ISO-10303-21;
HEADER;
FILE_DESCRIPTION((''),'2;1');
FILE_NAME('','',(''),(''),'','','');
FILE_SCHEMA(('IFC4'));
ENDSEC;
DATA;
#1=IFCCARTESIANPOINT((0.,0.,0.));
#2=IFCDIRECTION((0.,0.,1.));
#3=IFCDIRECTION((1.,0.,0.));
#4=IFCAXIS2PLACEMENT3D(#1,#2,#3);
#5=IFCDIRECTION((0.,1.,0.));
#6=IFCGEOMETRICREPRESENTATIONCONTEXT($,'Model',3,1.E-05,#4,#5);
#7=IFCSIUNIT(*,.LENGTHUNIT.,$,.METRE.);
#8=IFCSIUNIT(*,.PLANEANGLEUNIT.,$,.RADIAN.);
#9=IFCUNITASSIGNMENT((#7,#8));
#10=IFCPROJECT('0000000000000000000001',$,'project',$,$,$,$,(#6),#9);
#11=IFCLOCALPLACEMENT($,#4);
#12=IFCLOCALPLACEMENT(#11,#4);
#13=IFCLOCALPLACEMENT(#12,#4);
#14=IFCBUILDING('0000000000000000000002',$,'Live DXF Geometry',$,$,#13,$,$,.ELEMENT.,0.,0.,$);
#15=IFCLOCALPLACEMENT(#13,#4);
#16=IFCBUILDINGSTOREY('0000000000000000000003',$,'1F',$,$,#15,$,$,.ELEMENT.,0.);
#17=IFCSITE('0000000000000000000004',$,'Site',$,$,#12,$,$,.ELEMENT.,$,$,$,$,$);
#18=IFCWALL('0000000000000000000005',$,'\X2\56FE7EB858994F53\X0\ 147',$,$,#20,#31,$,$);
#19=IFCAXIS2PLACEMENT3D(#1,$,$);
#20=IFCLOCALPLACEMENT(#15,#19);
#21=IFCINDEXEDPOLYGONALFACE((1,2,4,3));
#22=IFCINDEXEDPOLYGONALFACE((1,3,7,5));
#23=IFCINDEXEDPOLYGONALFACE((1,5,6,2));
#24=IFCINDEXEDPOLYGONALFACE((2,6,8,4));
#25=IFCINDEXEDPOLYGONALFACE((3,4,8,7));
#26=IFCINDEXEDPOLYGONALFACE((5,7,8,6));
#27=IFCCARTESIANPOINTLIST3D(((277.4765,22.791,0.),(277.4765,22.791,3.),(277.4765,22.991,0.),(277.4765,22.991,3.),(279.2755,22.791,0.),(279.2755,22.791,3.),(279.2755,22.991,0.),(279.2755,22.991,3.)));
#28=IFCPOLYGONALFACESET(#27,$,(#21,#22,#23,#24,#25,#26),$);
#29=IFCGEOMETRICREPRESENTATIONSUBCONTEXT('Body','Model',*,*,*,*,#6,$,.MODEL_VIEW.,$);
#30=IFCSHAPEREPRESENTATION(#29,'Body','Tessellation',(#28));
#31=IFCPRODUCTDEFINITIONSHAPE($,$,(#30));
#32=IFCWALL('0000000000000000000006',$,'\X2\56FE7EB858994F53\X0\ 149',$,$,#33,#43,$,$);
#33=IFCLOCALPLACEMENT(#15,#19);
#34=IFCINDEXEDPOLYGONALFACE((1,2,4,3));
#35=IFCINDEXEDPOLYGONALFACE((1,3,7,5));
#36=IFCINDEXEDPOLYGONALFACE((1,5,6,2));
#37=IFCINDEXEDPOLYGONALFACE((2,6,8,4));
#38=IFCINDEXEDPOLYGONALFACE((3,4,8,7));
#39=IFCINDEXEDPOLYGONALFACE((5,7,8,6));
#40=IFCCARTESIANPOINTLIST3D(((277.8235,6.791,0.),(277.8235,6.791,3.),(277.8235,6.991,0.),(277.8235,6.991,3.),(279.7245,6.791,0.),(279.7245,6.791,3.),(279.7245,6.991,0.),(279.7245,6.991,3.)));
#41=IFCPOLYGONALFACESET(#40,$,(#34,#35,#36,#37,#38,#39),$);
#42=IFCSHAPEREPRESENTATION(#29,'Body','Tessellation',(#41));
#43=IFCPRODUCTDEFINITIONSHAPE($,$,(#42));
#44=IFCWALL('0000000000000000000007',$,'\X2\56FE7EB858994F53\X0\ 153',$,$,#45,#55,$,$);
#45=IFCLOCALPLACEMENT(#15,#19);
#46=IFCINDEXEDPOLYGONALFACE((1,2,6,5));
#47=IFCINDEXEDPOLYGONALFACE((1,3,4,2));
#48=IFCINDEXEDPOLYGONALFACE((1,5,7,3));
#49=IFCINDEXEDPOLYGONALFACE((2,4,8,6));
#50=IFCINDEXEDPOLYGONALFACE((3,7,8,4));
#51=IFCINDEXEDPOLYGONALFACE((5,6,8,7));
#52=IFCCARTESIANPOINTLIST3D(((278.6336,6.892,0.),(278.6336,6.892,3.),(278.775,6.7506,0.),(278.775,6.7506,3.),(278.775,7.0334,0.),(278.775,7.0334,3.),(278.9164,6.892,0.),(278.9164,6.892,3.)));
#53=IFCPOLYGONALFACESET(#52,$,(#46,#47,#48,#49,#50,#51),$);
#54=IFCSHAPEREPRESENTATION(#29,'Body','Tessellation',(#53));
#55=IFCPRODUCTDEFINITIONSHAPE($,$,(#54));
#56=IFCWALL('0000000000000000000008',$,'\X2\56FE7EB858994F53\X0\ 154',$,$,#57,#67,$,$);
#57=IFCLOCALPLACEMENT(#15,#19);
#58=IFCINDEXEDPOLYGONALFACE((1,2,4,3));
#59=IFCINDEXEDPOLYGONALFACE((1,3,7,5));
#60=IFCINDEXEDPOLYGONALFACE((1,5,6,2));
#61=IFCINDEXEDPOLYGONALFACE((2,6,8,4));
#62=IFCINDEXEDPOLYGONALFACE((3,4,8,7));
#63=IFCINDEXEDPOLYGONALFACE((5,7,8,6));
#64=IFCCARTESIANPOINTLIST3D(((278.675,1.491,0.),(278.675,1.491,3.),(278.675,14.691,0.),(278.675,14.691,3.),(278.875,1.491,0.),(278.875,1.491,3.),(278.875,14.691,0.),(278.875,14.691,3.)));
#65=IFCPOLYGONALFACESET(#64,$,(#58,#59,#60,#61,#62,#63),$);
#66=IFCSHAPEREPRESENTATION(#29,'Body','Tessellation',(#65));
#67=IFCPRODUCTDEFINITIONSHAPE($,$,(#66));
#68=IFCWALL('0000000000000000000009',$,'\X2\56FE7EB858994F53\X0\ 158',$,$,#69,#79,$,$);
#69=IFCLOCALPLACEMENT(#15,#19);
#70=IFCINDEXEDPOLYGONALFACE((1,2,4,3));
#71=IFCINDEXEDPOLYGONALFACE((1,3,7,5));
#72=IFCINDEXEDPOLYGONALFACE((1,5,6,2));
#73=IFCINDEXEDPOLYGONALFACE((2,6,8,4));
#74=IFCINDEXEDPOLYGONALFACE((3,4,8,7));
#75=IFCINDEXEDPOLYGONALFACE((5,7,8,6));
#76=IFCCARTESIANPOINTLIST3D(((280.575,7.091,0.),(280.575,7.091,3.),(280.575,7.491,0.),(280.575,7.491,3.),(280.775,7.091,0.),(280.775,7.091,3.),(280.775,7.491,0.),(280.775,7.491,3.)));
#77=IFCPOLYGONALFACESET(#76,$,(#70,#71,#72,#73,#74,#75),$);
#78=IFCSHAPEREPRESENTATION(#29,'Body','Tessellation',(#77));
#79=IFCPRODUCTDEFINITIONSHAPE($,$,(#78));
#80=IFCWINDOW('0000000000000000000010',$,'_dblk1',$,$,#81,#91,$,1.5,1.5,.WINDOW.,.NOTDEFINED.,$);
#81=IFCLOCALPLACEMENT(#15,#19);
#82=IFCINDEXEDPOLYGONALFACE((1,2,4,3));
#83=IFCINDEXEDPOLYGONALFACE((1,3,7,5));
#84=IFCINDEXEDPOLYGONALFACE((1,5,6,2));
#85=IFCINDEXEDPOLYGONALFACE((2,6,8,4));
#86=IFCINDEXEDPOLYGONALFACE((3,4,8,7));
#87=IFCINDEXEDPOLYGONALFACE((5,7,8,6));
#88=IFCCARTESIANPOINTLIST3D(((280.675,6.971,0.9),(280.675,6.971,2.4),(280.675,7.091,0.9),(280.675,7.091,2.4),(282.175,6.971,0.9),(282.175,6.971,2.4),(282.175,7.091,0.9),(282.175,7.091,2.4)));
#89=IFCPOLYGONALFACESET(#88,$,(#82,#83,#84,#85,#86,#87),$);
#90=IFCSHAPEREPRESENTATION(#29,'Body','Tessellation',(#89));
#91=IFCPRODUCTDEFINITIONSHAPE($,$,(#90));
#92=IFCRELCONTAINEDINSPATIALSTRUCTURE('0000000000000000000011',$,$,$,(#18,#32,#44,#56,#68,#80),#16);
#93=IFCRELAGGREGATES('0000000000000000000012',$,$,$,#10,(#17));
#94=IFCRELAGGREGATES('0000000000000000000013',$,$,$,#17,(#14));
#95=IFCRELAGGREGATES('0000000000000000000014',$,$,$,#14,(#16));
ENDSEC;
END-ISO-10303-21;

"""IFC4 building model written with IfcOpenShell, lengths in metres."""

from ifc_helpers import new_model, si_unit, direction, frame, frame_2d, origin_with_axes, place, context, subcontext, project, spatial, rectangle, extrude, element, save


model = new_model("IFC4")

# Units and contexts
model_context = context("Model", 3, precision=1e-05, world=origin_with_axes(), true_north=direction((0.0, 1.0, 0.0)))
body_context = subcontext(model_context, "Body", "Model", "MODEL_VIEW")
ifc_project = project(units=[si_unit("LENGTHUNIT", "METRE"), si_unit("PLANEANGLEUNIT", "RADIAN")], contexts=[model_context])

# Site, building, storey
placement = place(None, origin_with_axes())
site_placement = place(placement, origin_with_axes())
site = spatial("IfcSite", under=ifc_project, at=site_placement, Name="Site", CompositionType="ELEMENT")
building_placement = place(site_placement, origin_with_axes())
building = spatial("IfcBuilding", under=site, at=building_placement, Name="Live DXF Geometry", CompositionType="ELEMENT", ElevationOfRefHeight=0.0, ElevationOfTerrain=0.0)
storey_placement = place(building_placement, origin_with_axes())
storey = spatial("IfcBuildingStorey", under=building, at=storey_placement, Name="1F", CompositionType="ELEMENT", Elevation=0.0)

# Walls
wall_1_placement = place(storey_placement, frame((278.376, 22.891, 0.0), z_axis=(0.0, 0.0, 1.0), x_axis=(1.0, 0.0, 0.0)))
element("IfcWall", 1, at=wall_1_placement, inside=storey, Name="图纸墙体 147", context=body_context, shape_type="SweptSolid", body=[
    extrude(rectangle(XDim=1.799, YDim=0.2, at=frame_2d((0.0, 0.0), x_axis=(1.0, 0.0, 0.0))), frame((0.0, 0.0, 0.0), z_axis=(0.0, 0.0, 1.0)), (0.0, 0.0, 1.0), 3.0),
])
wall_2_placement = place(storey_placement, frame((278.774, 6.891, 0.0), z_axis=(0.0, 0.0, 1.0), x_axis=(1.0, 0.0, 0.0)))
element("IfcWall", 2, at=wall_2_placement, inside=storey, Name="图纸墙体 149", context=body_context, shape_type="SweptSolid", body=[
    extrude(rectangle(XDim=1.901, YDim=0.2, at=frame_2d((0.0, 0.0), x_axis=(1.0, 0.0, 0.0))), frame((0.0, 0.0, 0.0), z_axis=(0.0, 0.0, 1.0)), (0.0, 0.0, 1.0), 3.0),
])
wall_3_placement = place(storey_placement, frame((278.775, 6.892, 0.0), z_axis=(0.0, 0.0, 1.0), x_axis=(-0.707107, -0.707107, 0.0)))
element("IfcWall", 3, at=wall_3_placement, inside=storey, Name="图纸墙体 153", context=body_context, shape_type="SweptSolid", body=[
    extrude(rectangle(XDim=0.2, YDim=0.2, at=frame_2d((0.0, 0.0), x_axis=(1.0, 0.0, 0.0))), frame((0.0, 0.0, 0.0), z_axis=(0.0, 0.0, 1.0)), (0.0, 0.0, 1.0), 3.0),
])
wall_4_placement = place(storey_placement, frame((278.775, 8.091, 0.0), z_axis=(0.0, 0.0, 1.0), x_axis=(0.0, 1.0, 0.0)))
element("IfcWall", 4, at=wall_4_placement, inside=storey, Name="图纸墙体 154", context=body_context, shape_type="SweptSolid", body=[
    extrude(rectangle(XDim=13.2, YDim=0.2, at=frame_2d((0.0, 0.0), x_axis=(1.0, 0.0, 0.0))), frame((0.0, 0.0, 0.0), z_axis=(0.0, 0.0, 1.0)), (0.0, 0.0, 1.0), 3.0),
])
wall_5_placement = place(storey_placement, frame((280.675, 7.291, 0.0), z_axis=(0.0, 0.0, 1.0), x_axis=(0.0, -1.0, 0.0)))
element("IfcWall", 5, at=wall_5_placement, inside=storey, Name="图纸墙体 158", context=body_context, shape_type="SweptSolid", body=[
    extrude(rectangle(XDim=0.4, YDim=0.2, at=frame_2d((0.0, 0.0), x_axis=(1.0, 0.0, 0.0))), frame((0.0, 0.0, 0.0), z_axis=(0.0, 0.0, 1.0)), (0.0, 0.0, 1.0), 3.0),
])

# Window
window_placement = place(storey_placement, frame((281.425, 7.031, 0.9), z_axis=(0.0, 0.0, 1.0), x_axis=(1.0, 0.0, 0.0)))
element("IfcWindow", 6, at=window_placement, inside=storey, Name="_dblk1", OverallHeight=1.5, OverallWidth=1.5, PartitioningType="NOTDEFINED", PredefinedType="WINDOW", context=body_context, shape_type="SweptSolid", body=[
    extrude(rectangle(XDim=1.5, YDim=0.12, at=frame_2d((0.0, 0.0), x_axis=(1.0, 0.0, 0.0))), frame((0.0, 0.0, 0.0), z_axis=(0.0, 0.0, 1.0)), (0.0, 0.0, 1.0), 1.5),
])

save(model, "model.ifc")
